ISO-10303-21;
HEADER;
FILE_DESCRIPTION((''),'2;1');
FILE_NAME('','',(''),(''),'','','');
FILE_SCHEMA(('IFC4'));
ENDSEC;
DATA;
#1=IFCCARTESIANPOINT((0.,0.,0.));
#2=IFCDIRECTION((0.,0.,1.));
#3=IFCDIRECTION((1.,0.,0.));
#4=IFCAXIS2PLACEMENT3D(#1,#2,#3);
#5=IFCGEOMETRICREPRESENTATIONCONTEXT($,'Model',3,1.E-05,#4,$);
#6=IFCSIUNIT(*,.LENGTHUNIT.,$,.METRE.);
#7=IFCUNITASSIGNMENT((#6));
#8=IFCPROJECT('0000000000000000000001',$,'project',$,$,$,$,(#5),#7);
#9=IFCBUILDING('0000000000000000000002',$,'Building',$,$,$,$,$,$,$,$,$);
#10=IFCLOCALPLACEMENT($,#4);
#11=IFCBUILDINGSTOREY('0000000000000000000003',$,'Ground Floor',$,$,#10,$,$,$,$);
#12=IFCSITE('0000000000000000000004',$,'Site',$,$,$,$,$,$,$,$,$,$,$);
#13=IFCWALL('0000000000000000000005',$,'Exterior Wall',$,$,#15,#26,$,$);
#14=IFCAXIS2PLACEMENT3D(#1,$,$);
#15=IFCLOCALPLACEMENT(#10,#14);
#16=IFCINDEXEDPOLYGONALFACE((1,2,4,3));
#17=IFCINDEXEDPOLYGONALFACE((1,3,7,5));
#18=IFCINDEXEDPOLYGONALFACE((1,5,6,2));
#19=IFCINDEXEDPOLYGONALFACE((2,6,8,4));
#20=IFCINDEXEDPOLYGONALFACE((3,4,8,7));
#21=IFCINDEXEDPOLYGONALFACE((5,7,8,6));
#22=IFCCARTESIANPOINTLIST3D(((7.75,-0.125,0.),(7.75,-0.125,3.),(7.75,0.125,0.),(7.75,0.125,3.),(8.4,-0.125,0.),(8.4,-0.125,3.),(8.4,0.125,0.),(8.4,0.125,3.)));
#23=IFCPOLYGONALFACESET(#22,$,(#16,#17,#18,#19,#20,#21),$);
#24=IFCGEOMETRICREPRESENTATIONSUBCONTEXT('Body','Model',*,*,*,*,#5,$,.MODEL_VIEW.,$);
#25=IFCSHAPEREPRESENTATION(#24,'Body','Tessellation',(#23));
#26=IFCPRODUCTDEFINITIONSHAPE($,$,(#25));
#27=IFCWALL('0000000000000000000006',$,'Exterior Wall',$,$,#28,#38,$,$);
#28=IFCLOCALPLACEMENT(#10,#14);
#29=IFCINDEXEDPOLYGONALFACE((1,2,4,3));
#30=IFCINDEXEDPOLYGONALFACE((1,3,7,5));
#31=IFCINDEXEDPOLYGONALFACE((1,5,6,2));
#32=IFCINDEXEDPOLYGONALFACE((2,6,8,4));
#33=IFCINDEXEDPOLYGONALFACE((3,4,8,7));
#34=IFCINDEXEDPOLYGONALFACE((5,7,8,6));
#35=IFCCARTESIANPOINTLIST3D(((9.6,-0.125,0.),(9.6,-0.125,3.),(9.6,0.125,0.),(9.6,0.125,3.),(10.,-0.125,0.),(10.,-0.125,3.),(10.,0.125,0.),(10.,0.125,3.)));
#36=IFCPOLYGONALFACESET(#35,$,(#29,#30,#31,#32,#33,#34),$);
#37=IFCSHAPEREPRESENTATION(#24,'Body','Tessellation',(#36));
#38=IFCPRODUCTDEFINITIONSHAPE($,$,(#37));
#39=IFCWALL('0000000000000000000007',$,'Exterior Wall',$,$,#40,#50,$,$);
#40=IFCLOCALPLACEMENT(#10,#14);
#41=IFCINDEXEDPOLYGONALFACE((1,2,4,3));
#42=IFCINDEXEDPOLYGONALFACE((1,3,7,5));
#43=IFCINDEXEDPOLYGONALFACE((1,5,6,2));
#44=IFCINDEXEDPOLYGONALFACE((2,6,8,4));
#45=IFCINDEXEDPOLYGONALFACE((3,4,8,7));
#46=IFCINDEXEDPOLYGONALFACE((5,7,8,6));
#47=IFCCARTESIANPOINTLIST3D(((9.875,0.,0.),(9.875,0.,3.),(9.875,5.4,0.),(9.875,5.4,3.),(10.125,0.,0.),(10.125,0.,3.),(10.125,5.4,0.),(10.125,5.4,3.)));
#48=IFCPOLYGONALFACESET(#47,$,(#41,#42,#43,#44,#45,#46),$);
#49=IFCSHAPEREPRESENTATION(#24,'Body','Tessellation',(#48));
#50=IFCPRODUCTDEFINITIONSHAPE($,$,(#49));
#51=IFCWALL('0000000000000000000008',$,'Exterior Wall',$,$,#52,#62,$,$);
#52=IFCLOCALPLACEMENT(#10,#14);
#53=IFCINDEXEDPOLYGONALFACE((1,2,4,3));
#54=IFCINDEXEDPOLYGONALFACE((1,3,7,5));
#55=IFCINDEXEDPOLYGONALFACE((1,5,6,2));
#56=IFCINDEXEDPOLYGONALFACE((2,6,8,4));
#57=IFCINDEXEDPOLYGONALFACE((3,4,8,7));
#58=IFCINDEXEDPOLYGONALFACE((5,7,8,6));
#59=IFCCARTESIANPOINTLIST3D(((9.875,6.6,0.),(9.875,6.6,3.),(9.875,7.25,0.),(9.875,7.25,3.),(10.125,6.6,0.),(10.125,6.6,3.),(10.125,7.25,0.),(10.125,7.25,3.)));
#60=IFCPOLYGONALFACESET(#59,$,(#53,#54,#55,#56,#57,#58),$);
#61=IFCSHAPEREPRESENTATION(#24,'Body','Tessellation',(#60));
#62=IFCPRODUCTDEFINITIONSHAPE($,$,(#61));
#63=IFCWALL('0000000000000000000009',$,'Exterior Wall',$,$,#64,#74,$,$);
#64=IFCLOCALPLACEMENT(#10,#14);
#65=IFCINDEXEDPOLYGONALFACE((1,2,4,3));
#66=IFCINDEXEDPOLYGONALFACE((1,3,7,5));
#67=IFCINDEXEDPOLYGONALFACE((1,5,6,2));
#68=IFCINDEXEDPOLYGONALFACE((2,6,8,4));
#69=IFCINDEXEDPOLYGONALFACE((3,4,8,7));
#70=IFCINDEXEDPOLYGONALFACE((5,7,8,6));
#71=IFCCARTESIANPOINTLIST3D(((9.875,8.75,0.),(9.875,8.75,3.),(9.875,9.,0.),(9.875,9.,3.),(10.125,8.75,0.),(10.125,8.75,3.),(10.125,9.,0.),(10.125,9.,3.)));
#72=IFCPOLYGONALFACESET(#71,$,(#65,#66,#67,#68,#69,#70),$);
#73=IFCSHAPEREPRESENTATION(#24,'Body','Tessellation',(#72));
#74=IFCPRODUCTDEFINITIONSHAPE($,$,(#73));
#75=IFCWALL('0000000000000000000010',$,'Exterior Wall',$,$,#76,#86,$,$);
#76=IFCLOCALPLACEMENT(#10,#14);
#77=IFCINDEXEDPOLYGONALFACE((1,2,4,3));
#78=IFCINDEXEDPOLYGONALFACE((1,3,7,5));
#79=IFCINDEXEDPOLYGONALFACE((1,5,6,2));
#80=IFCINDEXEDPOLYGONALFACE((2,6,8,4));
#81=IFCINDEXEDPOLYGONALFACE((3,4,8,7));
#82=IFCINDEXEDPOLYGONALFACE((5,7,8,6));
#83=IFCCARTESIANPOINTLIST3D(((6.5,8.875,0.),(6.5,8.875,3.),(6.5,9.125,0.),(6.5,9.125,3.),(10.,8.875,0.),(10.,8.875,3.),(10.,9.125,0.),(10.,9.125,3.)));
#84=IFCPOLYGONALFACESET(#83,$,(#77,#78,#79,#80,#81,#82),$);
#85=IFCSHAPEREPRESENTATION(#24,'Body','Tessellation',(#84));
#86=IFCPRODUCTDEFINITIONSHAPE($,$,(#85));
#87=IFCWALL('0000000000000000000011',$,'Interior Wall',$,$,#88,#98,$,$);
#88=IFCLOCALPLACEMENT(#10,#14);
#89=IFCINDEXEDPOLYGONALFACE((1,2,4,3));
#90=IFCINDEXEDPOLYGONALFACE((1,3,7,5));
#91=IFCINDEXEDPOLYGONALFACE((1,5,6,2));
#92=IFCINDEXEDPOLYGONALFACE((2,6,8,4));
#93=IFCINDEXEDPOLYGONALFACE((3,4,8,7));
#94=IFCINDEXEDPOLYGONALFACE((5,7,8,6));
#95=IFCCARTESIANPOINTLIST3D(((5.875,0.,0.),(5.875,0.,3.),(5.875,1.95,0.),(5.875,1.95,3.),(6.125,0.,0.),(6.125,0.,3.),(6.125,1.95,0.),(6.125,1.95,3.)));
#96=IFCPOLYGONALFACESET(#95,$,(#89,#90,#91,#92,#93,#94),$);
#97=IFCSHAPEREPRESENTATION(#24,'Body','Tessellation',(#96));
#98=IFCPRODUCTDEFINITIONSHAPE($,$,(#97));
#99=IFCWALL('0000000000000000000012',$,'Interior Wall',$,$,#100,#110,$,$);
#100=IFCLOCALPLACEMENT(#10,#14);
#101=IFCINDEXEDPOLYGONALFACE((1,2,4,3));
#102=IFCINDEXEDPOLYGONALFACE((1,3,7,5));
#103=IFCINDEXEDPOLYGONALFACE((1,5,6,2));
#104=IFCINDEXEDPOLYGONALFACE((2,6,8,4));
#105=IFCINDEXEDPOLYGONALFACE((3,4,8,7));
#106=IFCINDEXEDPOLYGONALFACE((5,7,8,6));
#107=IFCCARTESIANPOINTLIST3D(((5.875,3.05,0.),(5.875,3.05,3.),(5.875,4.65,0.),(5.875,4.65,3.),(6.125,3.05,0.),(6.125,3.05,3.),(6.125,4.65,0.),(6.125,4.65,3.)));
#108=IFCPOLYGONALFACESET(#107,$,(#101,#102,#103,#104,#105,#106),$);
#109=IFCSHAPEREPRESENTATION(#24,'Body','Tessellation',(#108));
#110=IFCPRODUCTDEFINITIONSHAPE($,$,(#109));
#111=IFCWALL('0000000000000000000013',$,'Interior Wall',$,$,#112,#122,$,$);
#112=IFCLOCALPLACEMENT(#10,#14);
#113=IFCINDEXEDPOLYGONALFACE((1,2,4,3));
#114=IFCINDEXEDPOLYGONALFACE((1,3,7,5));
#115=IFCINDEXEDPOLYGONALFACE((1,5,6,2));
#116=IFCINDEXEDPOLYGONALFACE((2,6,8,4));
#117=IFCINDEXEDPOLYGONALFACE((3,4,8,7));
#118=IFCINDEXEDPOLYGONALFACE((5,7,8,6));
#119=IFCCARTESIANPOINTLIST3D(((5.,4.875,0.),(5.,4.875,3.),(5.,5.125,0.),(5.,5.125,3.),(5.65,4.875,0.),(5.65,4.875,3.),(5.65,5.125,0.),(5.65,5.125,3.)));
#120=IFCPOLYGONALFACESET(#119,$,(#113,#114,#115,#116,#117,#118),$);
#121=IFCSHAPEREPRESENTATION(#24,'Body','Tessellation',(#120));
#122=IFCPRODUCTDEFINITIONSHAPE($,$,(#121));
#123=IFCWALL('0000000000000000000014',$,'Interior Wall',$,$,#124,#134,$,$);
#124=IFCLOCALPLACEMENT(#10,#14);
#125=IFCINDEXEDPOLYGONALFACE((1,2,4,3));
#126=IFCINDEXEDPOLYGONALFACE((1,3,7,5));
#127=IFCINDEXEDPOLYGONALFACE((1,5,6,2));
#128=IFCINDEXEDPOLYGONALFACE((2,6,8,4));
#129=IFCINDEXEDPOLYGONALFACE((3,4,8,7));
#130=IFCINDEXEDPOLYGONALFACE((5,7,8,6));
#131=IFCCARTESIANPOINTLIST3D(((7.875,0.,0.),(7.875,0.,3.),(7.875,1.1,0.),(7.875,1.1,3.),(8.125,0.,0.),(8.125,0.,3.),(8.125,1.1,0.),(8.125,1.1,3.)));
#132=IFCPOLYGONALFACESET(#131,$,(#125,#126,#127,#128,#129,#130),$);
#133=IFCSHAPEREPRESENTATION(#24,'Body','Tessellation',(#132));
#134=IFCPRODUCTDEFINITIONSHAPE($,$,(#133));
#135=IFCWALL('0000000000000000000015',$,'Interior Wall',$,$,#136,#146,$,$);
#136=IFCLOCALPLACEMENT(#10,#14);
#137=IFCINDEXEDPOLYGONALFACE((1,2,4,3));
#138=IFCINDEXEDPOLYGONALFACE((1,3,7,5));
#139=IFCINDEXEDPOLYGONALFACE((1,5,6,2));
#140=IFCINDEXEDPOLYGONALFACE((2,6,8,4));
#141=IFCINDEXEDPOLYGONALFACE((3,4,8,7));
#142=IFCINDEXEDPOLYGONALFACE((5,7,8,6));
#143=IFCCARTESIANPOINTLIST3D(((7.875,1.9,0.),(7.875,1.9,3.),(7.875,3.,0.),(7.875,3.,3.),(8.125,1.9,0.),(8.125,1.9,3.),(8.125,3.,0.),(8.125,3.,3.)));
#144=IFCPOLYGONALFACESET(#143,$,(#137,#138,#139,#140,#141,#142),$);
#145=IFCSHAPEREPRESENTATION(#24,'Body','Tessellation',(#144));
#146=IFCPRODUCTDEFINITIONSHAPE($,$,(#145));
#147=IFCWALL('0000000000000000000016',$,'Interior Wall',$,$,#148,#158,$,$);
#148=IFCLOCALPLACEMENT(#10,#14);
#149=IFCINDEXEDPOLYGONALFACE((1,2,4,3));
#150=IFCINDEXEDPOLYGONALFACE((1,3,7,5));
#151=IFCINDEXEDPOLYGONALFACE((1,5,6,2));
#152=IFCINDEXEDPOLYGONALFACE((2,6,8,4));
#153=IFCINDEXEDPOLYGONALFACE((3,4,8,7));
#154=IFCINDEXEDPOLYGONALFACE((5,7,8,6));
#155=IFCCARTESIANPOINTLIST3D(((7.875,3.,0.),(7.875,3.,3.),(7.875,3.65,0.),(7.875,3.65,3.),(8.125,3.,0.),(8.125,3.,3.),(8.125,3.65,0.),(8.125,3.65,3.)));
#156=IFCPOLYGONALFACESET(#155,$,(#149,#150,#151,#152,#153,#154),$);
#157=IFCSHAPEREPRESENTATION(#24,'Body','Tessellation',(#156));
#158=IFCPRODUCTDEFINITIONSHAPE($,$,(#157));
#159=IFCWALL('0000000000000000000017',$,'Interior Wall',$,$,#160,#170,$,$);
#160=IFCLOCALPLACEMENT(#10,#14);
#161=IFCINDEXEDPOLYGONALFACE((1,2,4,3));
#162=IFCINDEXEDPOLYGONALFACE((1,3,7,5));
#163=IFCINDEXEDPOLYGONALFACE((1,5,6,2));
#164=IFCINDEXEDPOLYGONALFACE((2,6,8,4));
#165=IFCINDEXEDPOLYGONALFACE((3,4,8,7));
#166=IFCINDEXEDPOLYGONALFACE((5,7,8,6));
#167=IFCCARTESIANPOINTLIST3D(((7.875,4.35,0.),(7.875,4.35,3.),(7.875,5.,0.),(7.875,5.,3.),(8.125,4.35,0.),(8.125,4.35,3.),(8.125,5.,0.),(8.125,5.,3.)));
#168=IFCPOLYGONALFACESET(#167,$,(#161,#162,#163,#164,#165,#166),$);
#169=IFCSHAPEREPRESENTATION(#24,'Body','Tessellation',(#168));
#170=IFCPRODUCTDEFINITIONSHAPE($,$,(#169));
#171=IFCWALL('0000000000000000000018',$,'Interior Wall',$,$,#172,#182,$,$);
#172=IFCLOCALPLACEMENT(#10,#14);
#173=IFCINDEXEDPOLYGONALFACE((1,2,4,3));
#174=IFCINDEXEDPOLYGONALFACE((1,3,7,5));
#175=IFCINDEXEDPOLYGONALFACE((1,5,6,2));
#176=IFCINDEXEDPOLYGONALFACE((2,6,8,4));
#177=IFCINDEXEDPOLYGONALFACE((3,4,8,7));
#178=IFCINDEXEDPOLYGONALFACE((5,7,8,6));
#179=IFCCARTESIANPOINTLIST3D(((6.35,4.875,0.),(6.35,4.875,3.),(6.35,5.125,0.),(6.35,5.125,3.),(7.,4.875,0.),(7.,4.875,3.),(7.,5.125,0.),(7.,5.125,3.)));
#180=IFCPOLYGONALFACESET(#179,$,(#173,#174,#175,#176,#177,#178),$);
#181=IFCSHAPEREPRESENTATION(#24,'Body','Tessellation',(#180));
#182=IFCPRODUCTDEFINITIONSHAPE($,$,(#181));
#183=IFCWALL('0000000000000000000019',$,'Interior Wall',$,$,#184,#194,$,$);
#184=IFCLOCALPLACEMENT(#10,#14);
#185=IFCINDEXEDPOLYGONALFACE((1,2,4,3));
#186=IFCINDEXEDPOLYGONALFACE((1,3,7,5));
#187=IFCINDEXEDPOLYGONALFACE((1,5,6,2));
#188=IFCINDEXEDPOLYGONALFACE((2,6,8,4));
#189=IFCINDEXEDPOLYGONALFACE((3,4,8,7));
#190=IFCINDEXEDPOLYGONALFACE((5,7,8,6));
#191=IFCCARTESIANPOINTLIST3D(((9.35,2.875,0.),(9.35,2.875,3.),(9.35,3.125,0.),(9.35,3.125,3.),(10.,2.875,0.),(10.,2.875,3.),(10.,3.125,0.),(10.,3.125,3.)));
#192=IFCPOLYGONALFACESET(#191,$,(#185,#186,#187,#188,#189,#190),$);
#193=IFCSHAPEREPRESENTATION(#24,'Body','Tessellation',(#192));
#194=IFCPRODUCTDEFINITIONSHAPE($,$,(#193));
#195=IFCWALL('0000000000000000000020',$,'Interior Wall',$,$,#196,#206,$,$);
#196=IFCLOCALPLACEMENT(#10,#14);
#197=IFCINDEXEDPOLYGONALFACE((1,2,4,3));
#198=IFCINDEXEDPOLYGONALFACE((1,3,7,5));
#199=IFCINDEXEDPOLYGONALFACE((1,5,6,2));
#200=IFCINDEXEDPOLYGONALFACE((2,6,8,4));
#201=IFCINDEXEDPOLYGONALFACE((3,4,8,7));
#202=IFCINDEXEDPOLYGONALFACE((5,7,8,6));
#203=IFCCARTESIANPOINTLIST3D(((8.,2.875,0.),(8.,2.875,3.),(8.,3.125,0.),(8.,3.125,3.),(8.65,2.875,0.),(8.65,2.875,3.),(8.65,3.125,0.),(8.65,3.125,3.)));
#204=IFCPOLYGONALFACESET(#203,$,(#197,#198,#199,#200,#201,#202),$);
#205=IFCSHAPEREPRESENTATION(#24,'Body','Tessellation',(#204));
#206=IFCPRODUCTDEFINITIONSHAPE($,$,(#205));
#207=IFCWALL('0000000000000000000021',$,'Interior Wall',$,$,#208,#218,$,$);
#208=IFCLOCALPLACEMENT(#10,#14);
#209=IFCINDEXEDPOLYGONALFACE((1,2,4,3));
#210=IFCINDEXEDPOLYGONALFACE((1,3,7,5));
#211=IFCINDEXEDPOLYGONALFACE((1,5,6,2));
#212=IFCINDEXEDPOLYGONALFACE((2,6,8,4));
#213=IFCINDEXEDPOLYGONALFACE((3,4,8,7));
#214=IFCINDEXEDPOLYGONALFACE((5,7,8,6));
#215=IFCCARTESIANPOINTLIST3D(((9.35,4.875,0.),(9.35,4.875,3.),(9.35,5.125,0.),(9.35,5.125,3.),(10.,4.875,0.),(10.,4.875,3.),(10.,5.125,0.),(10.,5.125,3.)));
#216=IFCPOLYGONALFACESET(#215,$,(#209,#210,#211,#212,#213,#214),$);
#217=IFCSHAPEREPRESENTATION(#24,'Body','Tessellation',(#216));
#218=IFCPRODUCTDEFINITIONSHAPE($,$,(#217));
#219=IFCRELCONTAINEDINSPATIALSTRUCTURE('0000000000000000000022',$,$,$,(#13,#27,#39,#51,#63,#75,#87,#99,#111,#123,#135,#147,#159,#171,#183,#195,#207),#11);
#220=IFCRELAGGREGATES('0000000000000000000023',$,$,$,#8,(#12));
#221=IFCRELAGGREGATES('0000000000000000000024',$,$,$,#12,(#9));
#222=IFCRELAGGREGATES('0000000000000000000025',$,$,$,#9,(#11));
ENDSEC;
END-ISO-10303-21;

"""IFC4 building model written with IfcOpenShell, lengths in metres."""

from ifc_helpers import new_model, si_unit, frame, origin_with_axes, place, context, subcontext, project, spatial, indexed_curve, outline, extrude, element, save


model = new_model("IFC4")

# Units and contexts
model_context = context("Model", 3, precision=1e-05, world=origin_with_axes())
body_context = subcontext(model_context, "Body", "Model", "MODEL_VIEW")
ifc_project = project(units=[si_unit("LENGTHUNIT", "METRE")], contexts=[model_context])

# Site, building, storey
site = spatial("IfcSite", under=ifc_project, Name="Site")
building = spatial("IfcBuilding", under=site, Name="Building")
storey_placement = place(None, origin_with_axes())
storey = spatial("IfcBuildingStorey", under=building, at=storey_placement, Name="Ground Floor")

# Walls
wall_1_placement = place(storey_placement, frame((7.75, 0.0, 0.0), z_axis=(0.0, 0.0, 1.0), x_axis=(1.0, 0.0, 0.0)))
element("IfcWall", 1, at=wall_1_placement, inside=storey, Name="Exterior Wall", context=body_context, shape_type="SweptSolid", body=[
    extrude(outline(indexed_curve([(0.0, 0.0), (0.0, 0.25), (0.65, 0.25), (0.65, 0.0), (0.0, 0.0)], self_intersect=False)), frame((0.0, -0.125, 0.0), z_axis=(0.0, 0.0, 1.0), x_axis=(1.0, 0.0, 0.0)), (0.0, 0.0, 1.0), 3.0),
])
wall_2_placement = place(storey_placement, frame((9.6, 0.0, 0.0), z_axis=(0.0, 0.0, 1.0), x_axis=(1.0, 0.0, 0.0)))
element("IfcWall", 2, at=wall_2_placement, inside=storey, Name="Exterior Wall", context=body_context, shape_type="SweptSolid", body=[
    extrude(outline(indexed_curve([(0.0, 0.0), (0.0, 0.25), (0.4, 0.25), (0.4, 0.0), (0.0, 0.0)], self_intersect=False)), frame((0.0, -0.125, 0.0), z_axis=(0.0, 0.0, 1.0), x_axis=(1.0, 0.0, 0.0)), (0.0, 0.0, 1.0), 3.0),
])
wall_3_placement = place(storey_placement, frame((10.0, 0.0, 0.0), z_axis=(0.0, 0.0, 1.0), x_axis=(0.0, 1.0, 0.0)))
element("IfcWall", 3, at=wall_3_placement, inside=storey, Name="Exterior Wall", context=body_context, shape_type="SweptSolid", body=[
    extrude(outline(indexed_curve([(0.0, 0.0), (0.0, 0.25), (5.4, 0.25), (5.4, 0.0), (0.0, 0.0)], self_intersect=False)), frame((0.0, -0.125, 0.0), z_axis=(0.0, 0.0, 1.0), x_axis=(1.0, 0.0, 0.0)), (0.0, 0.0, 1.0), 3.0),
])
wall_4_placement = place(storey_placement, frame((10.0, 6.6, 0.0), z_axis=(0.0, 0.0, 1.0), x_axis=(0.0, 1.0, 0.0)))
element("IfcWall", 4, at=wall_4_placement, inside=storey, Name="Exterior Wall", context=body_context, shape_type="SweptSolid", body=[
    extrude(outline(indexed_curve([(0.0, 0.0), (0.0, 0.25), (0.65, 0.25), (0.65, 0.0), (0.0, 0.0)], self_intersect=False)), frame((0.0, -0.125, 0.0), z_axis=(0.0, 0.0, 1.0), x_axis=(1.0, 0.0, 0.0)), (0.0, 0.0, 1.0), 3.0),
])
wall_5_placement = place(storey_placement, frame((10.0, 8.75, 0.0), z_axis=(0.0, 0.0, 1.0), x_axis=(0.0, 1.0, 0.0)))
element("IfcWall", 5, at=wall_5_placement, inside=storey, Name="Exterior Wall", context=body_context, shape_type="SweptSolid", body=[
    extrude(outline(indexed_curve([(0.0, 0.0), (0.0, 0.25), (0.25, 0.25), (0.25, 0.0), (0.0, 0.0)], self_intersect=False)), frame((0.0, -0.125, 0.0), z_axis=(0.0, 0.0, 1.0), x_axis=(1.0, 0.0, 0.0)), (0.0, 0.0, 1.0), 3.0),
])
wall_6_placement = place(storey_placement, frame((10.0, 9.0, 0.0), z_axis=(0.0, 0.0, 1.0), x_axis=(-1.0, 0.0, 0.0)))
element("IfcWall", 6, at=wall_6_placement, inside=storey, Name="Exterior Wall", context=body_context, shape_type="SweptSolid", body=[
    extrude(outline(indexed_curve([(0.0, 0.0), (0.0, 0.25), (3.5, 0.25), (3.5, 0.0), (0.0, 0.0)], self_intersect=False)), frame((0.0, -0.125, 0.0), z_axis=(0.0, 0.0, 1.0), x_axis=(1.0, 0.0, 0.0)), (0.0, 0.0, 1.0), 3.0),
])
wall_7_placement = place(storey_placement, frame((6.0, 0.0, 0.0), z_axis=(0.0, 0.0, 1.0), x_axis=(0.0, 1.0, 0.0)))
element("IfcWall", 7, at=wall_7_placement, inside=storey, Name="Interior Wall", context=body_context, shape_type="SweptSolid", body=[
    extrude(outline(indexed_curve([(0.0, 0.0), (0.0, 0.25), (1.95, 0.25), (1.95, 0.0), (0.0, 0.0)], self_intersect=False)), frame((0.0, -0.125, 0.0), z_axis=(0.0, 0.0, 1.0), x_axis=(1.0, 0.0, 0.0)), (0.0, 0.0, 1.0), 3.0),
])
wall_8_placement = place(storey_placement, frame((6.0, 3.05, 0.0), z_axis=(0.0, 0.0, 1.0), x_axis=(0.0, 1.0, 0.0)))
element("IfcWall", 8, at=wall_8_placement, inside=storey, Name="Interior Wall", context=body_context, shape_type="SweptSolid", body=[
    extrude(outline(indexed_curve([(0.0, 0.0), (0.0, 0.25), (1.6, 0.25), (1.6, 0.0), (0.0, 0.0)], self_intersect=False)), frame((0.0, -0.125, 0.0), z_axis=(0.0, 0.0, 1.0), x_axis=(1.0, 0.0, 0.0)), (0.0, 0.0, 1.0), 3.0),
])
wall_9_placement = place(storey_placement, frame((5.65, 5.0, 0.0), z_axis=(0.0, 0.0, 1.0), x_axis=(-1.0, 0.0, 0.0)))
element("IfcWall", 9, at=wall_9_placement, inside=storey, Name="Interior Wall", context=body_context, shape_type="SweptSolid", body=[
    extrude(outline(indexed_curve([(0.0, 0.0), (0.0, 0.25), (0.65, 0.25), (0.65, 0.0), (0.0, 0.0)], self_intersect=False)), frame((0.0, -0.125, 0.0), z_axis=(0.0, 0.0, 1.0), x_axis=(1.0, 0.0, 0.0)), (0.0, 0.0, 1.0), 3.0),
])
for number, where, z_axis, x_axis, name in (
    (10, (8.0, 0.0, 0.0), (0.0, 0.0, 1.0), (0.0, 1.0, 0.0), "Interior Wall"),
    (11, (8.0, 1.9, 0.0), (0.0, 0.0, 1.0), (0.0, 1.0, 0.0), "Interior Wall"),
):
    element("IfcWall", number, at=place(storey_placement, frame(where, z_axis=z_axis, x_axis=x_axis)), inside=storey, Name=name, context=body_context, shape_type="SweptSolid", body=[
        extrude(outline(indexed_curve([(0.0, 0.0), (0.0, 0.25), (1.1, 0.25), (1.1, 0.0), (0.0, 0.0)], self_intersect=False)), frame((0.0, -0.125, 0.0), z_axis=(0.0, 0.0, 1.0), x_axis=(1.0, 0.0, 0.0)), (0.0, 0.0, 1.0), 3.0),
    ])
wall_10_placement = place(storey_placement, frame((8.0, 3.0, 0.0), z_axis=(0.0, 0.0, 1.0), x_axis=(0.0, 1.0, 0.0)))
element("IfcWall", 12, at=wall_10_placement, inside=storey, Name="Interior Wall", context=body_context, shape_type="SweptSolid", body=[
    extrude(outline(indexed_curve([(0.0, 0.0), (0.0, 0.25), (0.65, 0.25), (0.65, 0.0), (0.0, 0.0)], self_intersect=False)), frame((0.0, -0.125, 0.0), z_axis=(0.0, 0.0, 1.0), x_axis=(1.0, 0.0, 0.0)), (0.0, 0.0, 1.0), 3.0),
])
for number, where, z_axis, x_axis, name in (
    (13, (8.0, 4.35, 0.0), (0.0, 0.0, 1.0), (0.0, 1.0, 0.0), "Interior Wall"),
    (14, (7.0, 5.0, 0.0), (0.0, 0.0, 1.0), (-1.0, 0.0, 0.0), "Interior Wall"),
    (15, (10.0, 3.0, 0.0), (0.0, 0.0, 1.0), (-1.0, 0.0, 0.0), "Interior Wall"),
    (16, (8.65, 3.0, 0.0), (0.0, 0.0, 1.0), (-1.0, 0.0, 0.0), "Interior Wall"),
    (17, (10.0, 5.0, 0.0), (0.0, 0.0, 1.0), (-1.0, 0.0, 0.0), "Interior Wall"),
):
    element("IfcWall", number, at=place(storey_placement, frame(where, z_axis=z_axis, x_axis=x_axis)), inside=storey, Name=name, context=body_context, shape_type="SweptSolid", body=[
        extrude(outline(indexed_curve([(0.0, 0.0), (0.0, 0.25), (0.65, 0.25), (0.65, 0.0), (0.0, 0.0)], self_intersect=False)), frame((0.0, -0.125, 0.0), z_axis=(0.0, 0.0, 1.0), x_axis=(1.0, 0.0, 0.0)), (0.0, 0.0, 1.0), 3.0),
    ])

save(model, "model.ifc")
